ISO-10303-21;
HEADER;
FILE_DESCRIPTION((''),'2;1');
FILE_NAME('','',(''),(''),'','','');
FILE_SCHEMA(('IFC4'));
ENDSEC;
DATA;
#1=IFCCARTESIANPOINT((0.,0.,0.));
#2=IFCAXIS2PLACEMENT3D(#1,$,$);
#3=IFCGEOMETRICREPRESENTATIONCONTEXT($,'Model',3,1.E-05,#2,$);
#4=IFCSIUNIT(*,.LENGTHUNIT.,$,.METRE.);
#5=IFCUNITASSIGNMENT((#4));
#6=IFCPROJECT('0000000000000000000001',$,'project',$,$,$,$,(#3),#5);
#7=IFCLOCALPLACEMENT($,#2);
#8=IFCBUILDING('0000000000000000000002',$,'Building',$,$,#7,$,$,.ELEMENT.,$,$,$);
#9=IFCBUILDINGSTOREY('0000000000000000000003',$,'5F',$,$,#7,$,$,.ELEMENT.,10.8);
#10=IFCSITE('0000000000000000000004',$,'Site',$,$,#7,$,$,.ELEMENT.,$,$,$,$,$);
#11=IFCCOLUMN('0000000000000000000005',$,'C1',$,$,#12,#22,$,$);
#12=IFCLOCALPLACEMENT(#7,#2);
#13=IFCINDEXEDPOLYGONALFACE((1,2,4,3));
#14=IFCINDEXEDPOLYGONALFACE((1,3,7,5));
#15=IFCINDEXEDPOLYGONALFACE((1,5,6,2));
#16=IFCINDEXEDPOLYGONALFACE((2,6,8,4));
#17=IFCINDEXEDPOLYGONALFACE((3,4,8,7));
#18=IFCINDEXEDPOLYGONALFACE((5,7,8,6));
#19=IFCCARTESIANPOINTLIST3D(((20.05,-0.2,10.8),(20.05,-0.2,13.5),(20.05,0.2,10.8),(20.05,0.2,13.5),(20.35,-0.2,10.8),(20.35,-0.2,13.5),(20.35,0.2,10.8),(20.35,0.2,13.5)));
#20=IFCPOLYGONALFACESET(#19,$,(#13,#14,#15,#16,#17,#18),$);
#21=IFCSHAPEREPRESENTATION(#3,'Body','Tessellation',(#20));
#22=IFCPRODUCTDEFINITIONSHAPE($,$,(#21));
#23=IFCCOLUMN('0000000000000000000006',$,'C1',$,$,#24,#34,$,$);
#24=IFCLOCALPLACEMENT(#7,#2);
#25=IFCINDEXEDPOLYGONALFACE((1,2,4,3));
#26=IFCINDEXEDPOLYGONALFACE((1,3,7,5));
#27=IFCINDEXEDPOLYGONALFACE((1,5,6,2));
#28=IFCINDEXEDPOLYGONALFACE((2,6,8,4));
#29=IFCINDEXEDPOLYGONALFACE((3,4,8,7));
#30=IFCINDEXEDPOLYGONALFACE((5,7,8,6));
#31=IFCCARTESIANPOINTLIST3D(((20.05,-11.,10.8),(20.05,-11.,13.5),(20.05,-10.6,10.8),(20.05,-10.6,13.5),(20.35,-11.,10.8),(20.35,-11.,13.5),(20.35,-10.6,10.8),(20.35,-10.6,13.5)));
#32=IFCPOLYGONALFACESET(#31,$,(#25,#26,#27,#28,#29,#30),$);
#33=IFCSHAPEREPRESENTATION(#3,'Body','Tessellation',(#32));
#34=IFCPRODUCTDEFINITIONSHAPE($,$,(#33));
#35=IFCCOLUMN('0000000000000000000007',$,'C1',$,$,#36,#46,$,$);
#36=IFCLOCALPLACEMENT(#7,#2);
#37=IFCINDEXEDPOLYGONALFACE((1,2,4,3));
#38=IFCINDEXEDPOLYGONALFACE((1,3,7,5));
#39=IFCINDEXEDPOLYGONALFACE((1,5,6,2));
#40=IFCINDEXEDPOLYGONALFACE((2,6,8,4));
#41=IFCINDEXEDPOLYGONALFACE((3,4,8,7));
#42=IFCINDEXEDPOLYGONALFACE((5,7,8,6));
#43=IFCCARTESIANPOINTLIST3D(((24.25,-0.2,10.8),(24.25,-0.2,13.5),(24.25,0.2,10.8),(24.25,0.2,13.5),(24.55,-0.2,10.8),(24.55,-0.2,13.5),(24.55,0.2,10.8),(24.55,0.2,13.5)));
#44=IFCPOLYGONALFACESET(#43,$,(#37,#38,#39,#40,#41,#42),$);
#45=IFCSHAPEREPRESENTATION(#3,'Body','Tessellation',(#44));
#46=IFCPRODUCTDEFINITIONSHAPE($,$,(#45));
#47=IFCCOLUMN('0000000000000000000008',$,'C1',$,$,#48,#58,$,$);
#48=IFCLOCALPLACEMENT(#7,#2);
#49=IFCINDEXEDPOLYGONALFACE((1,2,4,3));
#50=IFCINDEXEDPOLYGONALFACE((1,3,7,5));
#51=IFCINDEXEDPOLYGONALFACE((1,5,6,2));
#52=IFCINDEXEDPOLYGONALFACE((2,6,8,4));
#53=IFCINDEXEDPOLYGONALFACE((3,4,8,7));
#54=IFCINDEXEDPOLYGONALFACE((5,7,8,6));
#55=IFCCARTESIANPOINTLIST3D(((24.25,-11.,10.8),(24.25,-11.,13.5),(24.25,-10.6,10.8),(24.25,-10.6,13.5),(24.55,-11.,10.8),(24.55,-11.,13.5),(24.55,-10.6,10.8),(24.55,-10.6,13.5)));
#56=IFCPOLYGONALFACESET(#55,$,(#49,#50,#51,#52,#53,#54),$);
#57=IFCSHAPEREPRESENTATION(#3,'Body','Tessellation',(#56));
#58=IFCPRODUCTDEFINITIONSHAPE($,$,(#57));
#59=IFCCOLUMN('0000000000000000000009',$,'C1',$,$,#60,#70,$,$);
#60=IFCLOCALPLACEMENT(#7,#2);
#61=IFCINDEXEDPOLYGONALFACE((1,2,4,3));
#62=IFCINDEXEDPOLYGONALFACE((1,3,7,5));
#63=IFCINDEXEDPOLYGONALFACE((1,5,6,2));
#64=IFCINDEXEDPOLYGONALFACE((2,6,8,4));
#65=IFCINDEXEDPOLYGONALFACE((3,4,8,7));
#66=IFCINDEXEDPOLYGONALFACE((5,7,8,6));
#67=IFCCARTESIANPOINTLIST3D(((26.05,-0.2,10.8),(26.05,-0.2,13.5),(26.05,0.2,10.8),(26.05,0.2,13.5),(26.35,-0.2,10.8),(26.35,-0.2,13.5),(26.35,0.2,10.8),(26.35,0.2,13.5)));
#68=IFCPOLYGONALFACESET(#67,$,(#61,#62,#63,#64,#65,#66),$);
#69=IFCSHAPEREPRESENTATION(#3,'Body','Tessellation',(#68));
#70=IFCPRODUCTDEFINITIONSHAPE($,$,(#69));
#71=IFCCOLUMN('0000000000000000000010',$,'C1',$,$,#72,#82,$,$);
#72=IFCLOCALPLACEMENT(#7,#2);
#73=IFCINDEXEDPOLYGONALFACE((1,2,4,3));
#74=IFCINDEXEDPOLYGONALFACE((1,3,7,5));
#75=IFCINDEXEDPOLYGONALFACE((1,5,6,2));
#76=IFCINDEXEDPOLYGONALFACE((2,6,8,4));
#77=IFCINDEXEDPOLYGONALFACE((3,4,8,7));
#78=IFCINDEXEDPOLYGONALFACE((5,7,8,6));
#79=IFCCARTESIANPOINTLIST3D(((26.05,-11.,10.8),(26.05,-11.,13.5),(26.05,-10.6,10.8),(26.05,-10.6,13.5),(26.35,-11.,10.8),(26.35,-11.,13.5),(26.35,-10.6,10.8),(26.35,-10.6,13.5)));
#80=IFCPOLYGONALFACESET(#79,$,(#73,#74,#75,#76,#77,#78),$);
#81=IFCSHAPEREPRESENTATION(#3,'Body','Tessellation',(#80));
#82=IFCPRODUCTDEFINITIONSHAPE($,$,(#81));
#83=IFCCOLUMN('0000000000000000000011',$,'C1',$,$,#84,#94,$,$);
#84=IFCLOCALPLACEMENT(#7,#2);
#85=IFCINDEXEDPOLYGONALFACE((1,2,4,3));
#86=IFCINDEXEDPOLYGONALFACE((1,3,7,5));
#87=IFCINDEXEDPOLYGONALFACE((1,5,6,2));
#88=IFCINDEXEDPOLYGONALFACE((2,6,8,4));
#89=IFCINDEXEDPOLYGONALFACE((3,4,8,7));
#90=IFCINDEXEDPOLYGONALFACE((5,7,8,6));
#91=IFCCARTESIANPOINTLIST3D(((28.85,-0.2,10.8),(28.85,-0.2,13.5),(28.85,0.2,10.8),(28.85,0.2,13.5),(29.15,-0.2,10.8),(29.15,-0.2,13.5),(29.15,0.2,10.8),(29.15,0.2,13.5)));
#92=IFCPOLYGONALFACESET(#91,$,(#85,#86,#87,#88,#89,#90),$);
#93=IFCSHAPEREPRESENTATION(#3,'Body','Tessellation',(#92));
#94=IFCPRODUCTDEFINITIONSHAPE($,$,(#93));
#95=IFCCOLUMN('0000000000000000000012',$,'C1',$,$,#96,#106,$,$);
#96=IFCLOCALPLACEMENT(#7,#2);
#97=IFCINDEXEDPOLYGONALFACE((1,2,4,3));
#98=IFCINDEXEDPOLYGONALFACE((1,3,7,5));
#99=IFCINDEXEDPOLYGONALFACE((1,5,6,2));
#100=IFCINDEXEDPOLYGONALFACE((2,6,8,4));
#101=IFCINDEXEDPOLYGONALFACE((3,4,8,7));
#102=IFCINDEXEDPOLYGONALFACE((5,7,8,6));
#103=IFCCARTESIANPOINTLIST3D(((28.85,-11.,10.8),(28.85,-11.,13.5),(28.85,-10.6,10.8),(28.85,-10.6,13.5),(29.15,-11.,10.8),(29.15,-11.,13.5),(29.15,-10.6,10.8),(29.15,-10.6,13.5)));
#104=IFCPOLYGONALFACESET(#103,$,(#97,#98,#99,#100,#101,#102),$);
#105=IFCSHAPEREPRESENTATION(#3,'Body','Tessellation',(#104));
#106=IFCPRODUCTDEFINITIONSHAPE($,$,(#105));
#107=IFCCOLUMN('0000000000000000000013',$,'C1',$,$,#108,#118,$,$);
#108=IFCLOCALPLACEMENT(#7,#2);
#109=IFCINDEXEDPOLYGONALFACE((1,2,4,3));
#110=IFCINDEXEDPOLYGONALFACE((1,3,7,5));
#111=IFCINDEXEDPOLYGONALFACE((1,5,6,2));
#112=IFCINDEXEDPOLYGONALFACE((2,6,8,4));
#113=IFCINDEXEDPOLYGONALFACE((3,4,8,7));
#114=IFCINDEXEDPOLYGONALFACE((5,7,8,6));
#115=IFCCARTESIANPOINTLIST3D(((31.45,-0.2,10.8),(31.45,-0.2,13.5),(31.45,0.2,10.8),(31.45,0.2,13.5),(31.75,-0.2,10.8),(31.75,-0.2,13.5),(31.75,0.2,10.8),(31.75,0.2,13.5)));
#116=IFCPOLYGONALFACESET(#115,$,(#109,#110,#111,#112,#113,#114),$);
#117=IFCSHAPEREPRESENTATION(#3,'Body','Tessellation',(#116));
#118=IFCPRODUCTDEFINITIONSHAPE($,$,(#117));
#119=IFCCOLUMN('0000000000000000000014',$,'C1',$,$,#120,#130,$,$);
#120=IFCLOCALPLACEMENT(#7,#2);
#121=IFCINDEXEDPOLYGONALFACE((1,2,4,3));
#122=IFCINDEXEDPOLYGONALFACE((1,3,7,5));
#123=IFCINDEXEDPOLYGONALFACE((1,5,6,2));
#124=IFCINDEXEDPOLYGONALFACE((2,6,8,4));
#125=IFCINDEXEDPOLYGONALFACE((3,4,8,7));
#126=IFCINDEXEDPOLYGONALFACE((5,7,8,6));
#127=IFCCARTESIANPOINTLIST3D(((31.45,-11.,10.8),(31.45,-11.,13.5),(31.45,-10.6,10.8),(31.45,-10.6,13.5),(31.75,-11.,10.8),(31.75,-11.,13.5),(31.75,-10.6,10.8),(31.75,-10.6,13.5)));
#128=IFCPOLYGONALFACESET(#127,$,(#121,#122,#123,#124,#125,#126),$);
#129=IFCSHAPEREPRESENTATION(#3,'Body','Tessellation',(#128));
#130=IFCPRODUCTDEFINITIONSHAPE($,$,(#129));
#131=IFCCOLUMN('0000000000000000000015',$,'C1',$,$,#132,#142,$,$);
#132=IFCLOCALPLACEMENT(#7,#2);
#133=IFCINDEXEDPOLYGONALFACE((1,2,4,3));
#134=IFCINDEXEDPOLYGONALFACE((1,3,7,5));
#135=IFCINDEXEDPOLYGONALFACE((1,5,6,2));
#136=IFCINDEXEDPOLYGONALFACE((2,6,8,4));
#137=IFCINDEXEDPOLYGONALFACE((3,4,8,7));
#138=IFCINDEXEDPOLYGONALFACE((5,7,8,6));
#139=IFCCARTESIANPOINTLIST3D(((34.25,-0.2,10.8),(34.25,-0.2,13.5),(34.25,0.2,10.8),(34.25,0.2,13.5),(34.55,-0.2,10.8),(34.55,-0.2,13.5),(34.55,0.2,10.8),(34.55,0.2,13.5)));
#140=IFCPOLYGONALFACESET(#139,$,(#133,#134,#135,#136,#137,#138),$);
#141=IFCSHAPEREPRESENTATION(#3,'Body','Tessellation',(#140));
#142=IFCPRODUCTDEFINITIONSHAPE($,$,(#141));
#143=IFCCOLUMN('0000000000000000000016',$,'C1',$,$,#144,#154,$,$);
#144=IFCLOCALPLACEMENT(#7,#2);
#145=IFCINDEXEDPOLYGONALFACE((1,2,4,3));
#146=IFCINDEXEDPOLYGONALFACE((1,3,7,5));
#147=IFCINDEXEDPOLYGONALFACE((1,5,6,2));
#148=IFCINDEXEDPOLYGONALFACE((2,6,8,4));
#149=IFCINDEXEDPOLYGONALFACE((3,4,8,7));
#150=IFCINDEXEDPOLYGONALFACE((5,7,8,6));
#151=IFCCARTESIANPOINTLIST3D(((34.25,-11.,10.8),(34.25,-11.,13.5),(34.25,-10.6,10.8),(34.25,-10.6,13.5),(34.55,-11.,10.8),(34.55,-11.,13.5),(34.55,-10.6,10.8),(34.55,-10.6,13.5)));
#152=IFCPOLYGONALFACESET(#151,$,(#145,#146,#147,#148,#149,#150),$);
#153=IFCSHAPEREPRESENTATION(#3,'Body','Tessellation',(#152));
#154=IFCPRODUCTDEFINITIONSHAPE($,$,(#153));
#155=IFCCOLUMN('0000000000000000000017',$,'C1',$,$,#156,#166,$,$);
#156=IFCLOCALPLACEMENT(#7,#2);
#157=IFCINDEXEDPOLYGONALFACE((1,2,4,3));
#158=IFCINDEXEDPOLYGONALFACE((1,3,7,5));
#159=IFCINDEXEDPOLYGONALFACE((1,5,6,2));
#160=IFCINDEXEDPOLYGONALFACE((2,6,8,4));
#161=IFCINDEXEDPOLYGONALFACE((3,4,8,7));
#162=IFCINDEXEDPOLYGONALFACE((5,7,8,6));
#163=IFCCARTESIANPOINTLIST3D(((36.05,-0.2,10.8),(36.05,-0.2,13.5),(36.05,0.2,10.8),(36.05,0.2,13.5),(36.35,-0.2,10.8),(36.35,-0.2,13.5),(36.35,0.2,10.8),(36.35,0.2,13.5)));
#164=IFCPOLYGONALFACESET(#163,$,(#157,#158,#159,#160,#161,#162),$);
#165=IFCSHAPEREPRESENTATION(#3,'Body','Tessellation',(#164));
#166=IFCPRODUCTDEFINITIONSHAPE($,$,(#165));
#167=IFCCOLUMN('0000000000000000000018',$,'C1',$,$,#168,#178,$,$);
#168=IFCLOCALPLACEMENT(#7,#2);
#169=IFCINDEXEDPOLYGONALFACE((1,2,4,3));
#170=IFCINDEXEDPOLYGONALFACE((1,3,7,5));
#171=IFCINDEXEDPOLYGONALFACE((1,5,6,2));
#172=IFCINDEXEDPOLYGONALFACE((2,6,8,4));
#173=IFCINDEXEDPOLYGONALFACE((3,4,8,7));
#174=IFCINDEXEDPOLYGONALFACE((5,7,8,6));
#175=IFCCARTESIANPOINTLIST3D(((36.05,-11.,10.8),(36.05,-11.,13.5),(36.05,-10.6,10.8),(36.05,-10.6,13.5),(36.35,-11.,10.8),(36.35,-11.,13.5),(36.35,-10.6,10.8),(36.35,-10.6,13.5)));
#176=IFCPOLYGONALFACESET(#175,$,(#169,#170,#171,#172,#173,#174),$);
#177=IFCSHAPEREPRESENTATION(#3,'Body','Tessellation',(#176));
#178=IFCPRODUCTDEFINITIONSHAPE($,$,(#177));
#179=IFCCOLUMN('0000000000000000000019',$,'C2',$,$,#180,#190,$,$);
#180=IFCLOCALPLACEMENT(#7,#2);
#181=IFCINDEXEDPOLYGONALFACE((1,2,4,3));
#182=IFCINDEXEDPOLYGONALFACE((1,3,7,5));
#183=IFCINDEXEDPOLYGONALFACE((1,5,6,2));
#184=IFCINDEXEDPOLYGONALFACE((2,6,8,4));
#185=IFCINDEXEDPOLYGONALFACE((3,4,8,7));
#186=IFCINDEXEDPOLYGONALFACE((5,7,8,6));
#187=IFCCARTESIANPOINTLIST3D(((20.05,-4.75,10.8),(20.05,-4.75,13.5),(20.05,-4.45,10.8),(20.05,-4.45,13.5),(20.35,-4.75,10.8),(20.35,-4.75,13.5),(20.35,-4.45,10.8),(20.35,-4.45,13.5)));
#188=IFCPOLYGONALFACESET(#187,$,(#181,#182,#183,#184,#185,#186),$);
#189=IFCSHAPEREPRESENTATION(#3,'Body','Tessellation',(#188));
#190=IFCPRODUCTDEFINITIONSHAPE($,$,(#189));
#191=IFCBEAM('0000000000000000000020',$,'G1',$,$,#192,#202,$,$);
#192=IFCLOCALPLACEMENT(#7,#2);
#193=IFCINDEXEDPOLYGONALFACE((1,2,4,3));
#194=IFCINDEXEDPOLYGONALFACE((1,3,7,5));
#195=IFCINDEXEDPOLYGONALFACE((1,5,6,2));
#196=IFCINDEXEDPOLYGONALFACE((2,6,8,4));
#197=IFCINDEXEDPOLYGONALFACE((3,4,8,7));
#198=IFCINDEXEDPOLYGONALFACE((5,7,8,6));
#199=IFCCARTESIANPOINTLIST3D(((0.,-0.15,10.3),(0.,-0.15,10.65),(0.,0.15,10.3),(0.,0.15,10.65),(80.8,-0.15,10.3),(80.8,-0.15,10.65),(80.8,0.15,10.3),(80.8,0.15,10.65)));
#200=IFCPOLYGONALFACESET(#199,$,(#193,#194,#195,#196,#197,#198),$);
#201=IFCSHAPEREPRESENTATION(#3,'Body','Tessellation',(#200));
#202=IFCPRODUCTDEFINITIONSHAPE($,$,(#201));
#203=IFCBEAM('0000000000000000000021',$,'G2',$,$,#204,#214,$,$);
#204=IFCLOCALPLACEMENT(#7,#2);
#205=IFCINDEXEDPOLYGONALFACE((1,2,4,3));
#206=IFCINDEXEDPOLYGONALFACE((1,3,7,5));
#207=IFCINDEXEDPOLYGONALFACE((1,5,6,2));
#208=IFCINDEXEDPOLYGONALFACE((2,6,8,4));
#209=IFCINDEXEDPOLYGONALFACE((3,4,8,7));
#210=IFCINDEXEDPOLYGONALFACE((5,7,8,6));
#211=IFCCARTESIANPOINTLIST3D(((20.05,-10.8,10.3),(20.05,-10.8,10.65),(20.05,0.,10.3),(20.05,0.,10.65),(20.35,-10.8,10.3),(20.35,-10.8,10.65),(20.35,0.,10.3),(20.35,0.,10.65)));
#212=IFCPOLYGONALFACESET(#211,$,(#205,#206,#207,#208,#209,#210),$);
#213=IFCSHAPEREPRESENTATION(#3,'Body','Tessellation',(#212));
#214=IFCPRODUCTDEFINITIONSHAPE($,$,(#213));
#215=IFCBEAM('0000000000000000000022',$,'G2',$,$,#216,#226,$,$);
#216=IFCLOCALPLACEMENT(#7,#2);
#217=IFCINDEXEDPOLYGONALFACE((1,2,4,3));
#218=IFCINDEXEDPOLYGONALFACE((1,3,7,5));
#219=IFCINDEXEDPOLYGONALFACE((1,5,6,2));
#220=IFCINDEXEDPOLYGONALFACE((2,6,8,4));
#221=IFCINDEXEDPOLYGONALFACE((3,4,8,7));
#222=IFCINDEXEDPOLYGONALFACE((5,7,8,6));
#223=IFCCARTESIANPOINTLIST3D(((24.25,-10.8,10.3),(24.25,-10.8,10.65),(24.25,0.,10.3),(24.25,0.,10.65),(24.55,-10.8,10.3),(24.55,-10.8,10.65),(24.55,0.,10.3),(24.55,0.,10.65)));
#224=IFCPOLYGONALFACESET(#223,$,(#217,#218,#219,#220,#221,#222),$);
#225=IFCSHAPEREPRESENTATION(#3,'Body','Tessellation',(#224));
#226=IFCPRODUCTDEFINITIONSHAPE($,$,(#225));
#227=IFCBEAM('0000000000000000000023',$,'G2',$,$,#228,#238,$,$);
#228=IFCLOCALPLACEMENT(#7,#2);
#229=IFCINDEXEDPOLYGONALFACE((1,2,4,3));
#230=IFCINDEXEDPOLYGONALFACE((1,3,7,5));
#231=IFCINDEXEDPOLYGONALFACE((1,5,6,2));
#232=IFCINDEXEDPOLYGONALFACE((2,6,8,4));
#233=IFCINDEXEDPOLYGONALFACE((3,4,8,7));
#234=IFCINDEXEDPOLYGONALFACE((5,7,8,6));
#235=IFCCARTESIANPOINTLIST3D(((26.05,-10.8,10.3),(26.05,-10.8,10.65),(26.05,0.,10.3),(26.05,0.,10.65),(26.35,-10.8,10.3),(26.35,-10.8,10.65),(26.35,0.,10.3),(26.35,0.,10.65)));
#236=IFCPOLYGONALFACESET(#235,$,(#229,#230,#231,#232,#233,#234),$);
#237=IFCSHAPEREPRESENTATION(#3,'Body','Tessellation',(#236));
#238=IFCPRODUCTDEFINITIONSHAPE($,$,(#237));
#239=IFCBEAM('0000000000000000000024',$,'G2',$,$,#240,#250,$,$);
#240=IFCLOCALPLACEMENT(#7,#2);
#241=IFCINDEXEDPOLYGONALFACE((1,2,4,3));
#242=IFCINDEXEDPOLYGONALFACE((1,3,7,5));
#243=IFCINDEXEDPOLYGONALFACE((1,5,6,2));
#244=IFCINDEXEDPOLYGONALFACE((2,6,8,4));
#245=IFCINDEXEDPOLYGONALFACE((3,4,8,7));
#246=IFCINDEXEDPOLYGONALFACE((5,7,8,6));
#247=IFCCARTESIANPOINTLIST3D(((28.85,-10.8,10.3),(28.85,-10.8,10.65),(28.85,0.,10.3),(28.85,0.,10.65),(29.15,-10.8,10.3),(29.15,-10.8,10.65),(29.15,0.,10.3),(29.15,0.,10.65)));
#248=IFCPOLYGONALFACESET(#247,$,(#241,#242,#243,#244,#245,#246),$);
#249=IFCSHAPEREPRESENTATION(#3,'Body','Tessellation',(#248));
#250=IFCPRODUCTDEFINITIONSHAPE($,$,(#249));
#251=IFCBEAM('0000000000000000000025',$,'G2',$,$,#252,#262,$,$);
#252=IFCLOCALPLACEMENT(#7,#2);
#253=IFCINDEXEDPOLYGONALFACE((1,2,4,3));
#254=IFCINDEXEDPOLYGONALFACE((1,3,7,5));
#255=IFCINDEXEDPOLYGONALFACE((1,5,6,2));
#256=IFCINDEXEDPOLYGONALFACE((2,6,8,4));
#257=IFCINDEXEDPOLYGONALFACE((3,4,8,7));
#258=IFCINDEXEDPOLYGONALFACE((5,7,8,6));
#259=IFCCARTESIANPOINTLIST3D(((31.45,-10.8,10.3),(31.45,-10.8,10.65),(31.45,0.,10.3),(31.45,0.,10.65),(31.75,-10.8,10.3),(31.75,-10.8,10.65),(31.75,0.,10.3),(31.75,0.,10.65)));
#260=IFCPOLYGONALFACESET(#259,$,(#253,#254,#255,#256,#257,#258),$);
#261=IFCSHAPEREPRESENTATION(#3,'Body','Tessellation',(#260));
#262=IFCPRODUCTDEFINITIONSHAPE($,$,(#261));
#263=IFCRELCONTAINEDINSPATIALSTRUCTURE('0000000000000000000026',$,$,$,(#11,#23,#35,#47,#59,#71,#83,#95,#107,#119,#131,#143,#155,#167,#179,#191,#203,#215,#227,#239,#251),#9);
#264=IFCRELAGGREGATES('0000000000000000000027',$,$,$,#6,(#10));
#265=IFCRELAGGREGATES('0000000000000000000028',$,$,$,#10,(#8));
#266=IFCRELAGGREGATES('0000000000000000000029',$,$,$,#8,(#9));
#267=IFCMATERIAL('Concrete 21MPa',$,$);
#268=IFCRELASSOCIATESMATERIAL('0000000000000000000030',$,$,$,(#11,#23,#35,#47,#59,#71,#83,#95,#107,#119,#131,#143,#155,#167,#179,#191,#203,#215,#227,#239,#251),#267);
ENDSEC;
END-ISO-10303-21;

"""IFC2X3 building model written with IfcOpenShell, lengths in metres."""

from ifc_helpers import new_model, si_unit, frame, origin, origin_2d, place, context, project, spatial, rectangle, extrude, material, element, save


model = new_model("IFC2X3")

# Units and contexts
model_context = context("Model", 3, precision=1e-05, world=origin())
ifc_project = project(units=[si_unit("LENGTHUNIT", "METRE")], contexts=[model_context])

# Site, building, storey
placement = place(None, origin())
site = spatial("IfcSite", under=ifc_project, at=placement, Name="Site", CompositionType="ELEMENT")
building = spatial("IfcBuilding", under=site, at=placement, Name="Building", CompositionType="ELEMENT")
storey = spatial("IfcBuildingStorey", under=building, at=placement, Name="5F", CompositionType="ELEMENT", Elevation=10.8)

# Columns
ifc_material_1 = material(Name="Concrete 21MPa")
for number, where, name in (
    (1, (20.2, 0.0, 10.8), "C1"),
    (2, (20.2, -10.8, 10.8), "C1"),
    (3, (24.4, 0.0, 10.8), "C1"),
    (4, (24.4, -10.8, 10.8), "C1"),
    (5, (26.2, 0.0, 10.8), "C1"),
    (6, (26.2, -10.8, 10.8), "C1"),
    (7, (29.0, 0.0, 10.8), "C1"),
    (8, (29.0, -10.8, 10.8), "C1"),
    (9, (31.6, 0.0, 10.8), "C1"),
    (10, (31.6, -10.8, 10.8), "C1"),
    (11, (34.4, 0.0, 10.8), "C1"),
    (12, (34.4, -10.8, 10.8), "C1"),
    (13, (36.2, 0.0, 10.8), "C1"),
    (14, (36.2, -10.8, 10.8), "C1"),
):
    element("IfcColumn", number, at=place(None, frame(where)), inside=storey, material=ifc_material_1, Name=name, context=model_context, shape_type="SweptSolid", body=[
        extrude(rectangle(XDim=0.3, YDim=0.4, at=origin_2d()), origin(), (0.0, 0.0, 1.0), 2.7),
    ])
column_placement = place(None, frame((20.2, -4.6, 10.8)))
element("IfcColumn", 15, at=column_placement, inside=storey, material=ifc_material_1, Name="C2", context=model_context, shape_type="SweptSolid", body=[
    extrude(rectangle(XDim=0.3, YDim=0.3, at=origin_2d()), origin(), (0.0, 0.0, 1.0), 2.7),
])

# Beams
beam_placement = place(None, frame((40.4, 0.0, 10.3)))
element("IfcBeam", 16, at=beam_placement, inside=storey, material=ifc_material_1, Name="G1", context=model_context, shape_type="SweptSolid", body=[
    extrude(rectangle(XDim=80.8, YDim=0.3, at=origin_2d()), origin(), (0.0, 0.0, 1.0), 0.35),
])
for number, where, name in (
    (17, (20.2, -5.4, 10.3), "G2"),
    (18, (24.4, -5.4, 10.3), "G2"),
    (19, (26.2, -5.4, 10.3), "G2"),
    (20, (29.0, -5.4, 10.3), "G2"),
    (21, (31.6, -5.4, 10.3), "G2"),
):
    element("IfcBeam", number, at=place(None, frame(where)), inside=storey, material=ifc_material_1, Name=name, context=model_context, shape_type="SweptSolid", body=[
        extrude(rectangle(XDim=0.3, YDim=10.8, at=origin_2d()), origin(), (0.0, 0.0, 1.0), 0.35),
    ])

save(model, "model.ifc")
